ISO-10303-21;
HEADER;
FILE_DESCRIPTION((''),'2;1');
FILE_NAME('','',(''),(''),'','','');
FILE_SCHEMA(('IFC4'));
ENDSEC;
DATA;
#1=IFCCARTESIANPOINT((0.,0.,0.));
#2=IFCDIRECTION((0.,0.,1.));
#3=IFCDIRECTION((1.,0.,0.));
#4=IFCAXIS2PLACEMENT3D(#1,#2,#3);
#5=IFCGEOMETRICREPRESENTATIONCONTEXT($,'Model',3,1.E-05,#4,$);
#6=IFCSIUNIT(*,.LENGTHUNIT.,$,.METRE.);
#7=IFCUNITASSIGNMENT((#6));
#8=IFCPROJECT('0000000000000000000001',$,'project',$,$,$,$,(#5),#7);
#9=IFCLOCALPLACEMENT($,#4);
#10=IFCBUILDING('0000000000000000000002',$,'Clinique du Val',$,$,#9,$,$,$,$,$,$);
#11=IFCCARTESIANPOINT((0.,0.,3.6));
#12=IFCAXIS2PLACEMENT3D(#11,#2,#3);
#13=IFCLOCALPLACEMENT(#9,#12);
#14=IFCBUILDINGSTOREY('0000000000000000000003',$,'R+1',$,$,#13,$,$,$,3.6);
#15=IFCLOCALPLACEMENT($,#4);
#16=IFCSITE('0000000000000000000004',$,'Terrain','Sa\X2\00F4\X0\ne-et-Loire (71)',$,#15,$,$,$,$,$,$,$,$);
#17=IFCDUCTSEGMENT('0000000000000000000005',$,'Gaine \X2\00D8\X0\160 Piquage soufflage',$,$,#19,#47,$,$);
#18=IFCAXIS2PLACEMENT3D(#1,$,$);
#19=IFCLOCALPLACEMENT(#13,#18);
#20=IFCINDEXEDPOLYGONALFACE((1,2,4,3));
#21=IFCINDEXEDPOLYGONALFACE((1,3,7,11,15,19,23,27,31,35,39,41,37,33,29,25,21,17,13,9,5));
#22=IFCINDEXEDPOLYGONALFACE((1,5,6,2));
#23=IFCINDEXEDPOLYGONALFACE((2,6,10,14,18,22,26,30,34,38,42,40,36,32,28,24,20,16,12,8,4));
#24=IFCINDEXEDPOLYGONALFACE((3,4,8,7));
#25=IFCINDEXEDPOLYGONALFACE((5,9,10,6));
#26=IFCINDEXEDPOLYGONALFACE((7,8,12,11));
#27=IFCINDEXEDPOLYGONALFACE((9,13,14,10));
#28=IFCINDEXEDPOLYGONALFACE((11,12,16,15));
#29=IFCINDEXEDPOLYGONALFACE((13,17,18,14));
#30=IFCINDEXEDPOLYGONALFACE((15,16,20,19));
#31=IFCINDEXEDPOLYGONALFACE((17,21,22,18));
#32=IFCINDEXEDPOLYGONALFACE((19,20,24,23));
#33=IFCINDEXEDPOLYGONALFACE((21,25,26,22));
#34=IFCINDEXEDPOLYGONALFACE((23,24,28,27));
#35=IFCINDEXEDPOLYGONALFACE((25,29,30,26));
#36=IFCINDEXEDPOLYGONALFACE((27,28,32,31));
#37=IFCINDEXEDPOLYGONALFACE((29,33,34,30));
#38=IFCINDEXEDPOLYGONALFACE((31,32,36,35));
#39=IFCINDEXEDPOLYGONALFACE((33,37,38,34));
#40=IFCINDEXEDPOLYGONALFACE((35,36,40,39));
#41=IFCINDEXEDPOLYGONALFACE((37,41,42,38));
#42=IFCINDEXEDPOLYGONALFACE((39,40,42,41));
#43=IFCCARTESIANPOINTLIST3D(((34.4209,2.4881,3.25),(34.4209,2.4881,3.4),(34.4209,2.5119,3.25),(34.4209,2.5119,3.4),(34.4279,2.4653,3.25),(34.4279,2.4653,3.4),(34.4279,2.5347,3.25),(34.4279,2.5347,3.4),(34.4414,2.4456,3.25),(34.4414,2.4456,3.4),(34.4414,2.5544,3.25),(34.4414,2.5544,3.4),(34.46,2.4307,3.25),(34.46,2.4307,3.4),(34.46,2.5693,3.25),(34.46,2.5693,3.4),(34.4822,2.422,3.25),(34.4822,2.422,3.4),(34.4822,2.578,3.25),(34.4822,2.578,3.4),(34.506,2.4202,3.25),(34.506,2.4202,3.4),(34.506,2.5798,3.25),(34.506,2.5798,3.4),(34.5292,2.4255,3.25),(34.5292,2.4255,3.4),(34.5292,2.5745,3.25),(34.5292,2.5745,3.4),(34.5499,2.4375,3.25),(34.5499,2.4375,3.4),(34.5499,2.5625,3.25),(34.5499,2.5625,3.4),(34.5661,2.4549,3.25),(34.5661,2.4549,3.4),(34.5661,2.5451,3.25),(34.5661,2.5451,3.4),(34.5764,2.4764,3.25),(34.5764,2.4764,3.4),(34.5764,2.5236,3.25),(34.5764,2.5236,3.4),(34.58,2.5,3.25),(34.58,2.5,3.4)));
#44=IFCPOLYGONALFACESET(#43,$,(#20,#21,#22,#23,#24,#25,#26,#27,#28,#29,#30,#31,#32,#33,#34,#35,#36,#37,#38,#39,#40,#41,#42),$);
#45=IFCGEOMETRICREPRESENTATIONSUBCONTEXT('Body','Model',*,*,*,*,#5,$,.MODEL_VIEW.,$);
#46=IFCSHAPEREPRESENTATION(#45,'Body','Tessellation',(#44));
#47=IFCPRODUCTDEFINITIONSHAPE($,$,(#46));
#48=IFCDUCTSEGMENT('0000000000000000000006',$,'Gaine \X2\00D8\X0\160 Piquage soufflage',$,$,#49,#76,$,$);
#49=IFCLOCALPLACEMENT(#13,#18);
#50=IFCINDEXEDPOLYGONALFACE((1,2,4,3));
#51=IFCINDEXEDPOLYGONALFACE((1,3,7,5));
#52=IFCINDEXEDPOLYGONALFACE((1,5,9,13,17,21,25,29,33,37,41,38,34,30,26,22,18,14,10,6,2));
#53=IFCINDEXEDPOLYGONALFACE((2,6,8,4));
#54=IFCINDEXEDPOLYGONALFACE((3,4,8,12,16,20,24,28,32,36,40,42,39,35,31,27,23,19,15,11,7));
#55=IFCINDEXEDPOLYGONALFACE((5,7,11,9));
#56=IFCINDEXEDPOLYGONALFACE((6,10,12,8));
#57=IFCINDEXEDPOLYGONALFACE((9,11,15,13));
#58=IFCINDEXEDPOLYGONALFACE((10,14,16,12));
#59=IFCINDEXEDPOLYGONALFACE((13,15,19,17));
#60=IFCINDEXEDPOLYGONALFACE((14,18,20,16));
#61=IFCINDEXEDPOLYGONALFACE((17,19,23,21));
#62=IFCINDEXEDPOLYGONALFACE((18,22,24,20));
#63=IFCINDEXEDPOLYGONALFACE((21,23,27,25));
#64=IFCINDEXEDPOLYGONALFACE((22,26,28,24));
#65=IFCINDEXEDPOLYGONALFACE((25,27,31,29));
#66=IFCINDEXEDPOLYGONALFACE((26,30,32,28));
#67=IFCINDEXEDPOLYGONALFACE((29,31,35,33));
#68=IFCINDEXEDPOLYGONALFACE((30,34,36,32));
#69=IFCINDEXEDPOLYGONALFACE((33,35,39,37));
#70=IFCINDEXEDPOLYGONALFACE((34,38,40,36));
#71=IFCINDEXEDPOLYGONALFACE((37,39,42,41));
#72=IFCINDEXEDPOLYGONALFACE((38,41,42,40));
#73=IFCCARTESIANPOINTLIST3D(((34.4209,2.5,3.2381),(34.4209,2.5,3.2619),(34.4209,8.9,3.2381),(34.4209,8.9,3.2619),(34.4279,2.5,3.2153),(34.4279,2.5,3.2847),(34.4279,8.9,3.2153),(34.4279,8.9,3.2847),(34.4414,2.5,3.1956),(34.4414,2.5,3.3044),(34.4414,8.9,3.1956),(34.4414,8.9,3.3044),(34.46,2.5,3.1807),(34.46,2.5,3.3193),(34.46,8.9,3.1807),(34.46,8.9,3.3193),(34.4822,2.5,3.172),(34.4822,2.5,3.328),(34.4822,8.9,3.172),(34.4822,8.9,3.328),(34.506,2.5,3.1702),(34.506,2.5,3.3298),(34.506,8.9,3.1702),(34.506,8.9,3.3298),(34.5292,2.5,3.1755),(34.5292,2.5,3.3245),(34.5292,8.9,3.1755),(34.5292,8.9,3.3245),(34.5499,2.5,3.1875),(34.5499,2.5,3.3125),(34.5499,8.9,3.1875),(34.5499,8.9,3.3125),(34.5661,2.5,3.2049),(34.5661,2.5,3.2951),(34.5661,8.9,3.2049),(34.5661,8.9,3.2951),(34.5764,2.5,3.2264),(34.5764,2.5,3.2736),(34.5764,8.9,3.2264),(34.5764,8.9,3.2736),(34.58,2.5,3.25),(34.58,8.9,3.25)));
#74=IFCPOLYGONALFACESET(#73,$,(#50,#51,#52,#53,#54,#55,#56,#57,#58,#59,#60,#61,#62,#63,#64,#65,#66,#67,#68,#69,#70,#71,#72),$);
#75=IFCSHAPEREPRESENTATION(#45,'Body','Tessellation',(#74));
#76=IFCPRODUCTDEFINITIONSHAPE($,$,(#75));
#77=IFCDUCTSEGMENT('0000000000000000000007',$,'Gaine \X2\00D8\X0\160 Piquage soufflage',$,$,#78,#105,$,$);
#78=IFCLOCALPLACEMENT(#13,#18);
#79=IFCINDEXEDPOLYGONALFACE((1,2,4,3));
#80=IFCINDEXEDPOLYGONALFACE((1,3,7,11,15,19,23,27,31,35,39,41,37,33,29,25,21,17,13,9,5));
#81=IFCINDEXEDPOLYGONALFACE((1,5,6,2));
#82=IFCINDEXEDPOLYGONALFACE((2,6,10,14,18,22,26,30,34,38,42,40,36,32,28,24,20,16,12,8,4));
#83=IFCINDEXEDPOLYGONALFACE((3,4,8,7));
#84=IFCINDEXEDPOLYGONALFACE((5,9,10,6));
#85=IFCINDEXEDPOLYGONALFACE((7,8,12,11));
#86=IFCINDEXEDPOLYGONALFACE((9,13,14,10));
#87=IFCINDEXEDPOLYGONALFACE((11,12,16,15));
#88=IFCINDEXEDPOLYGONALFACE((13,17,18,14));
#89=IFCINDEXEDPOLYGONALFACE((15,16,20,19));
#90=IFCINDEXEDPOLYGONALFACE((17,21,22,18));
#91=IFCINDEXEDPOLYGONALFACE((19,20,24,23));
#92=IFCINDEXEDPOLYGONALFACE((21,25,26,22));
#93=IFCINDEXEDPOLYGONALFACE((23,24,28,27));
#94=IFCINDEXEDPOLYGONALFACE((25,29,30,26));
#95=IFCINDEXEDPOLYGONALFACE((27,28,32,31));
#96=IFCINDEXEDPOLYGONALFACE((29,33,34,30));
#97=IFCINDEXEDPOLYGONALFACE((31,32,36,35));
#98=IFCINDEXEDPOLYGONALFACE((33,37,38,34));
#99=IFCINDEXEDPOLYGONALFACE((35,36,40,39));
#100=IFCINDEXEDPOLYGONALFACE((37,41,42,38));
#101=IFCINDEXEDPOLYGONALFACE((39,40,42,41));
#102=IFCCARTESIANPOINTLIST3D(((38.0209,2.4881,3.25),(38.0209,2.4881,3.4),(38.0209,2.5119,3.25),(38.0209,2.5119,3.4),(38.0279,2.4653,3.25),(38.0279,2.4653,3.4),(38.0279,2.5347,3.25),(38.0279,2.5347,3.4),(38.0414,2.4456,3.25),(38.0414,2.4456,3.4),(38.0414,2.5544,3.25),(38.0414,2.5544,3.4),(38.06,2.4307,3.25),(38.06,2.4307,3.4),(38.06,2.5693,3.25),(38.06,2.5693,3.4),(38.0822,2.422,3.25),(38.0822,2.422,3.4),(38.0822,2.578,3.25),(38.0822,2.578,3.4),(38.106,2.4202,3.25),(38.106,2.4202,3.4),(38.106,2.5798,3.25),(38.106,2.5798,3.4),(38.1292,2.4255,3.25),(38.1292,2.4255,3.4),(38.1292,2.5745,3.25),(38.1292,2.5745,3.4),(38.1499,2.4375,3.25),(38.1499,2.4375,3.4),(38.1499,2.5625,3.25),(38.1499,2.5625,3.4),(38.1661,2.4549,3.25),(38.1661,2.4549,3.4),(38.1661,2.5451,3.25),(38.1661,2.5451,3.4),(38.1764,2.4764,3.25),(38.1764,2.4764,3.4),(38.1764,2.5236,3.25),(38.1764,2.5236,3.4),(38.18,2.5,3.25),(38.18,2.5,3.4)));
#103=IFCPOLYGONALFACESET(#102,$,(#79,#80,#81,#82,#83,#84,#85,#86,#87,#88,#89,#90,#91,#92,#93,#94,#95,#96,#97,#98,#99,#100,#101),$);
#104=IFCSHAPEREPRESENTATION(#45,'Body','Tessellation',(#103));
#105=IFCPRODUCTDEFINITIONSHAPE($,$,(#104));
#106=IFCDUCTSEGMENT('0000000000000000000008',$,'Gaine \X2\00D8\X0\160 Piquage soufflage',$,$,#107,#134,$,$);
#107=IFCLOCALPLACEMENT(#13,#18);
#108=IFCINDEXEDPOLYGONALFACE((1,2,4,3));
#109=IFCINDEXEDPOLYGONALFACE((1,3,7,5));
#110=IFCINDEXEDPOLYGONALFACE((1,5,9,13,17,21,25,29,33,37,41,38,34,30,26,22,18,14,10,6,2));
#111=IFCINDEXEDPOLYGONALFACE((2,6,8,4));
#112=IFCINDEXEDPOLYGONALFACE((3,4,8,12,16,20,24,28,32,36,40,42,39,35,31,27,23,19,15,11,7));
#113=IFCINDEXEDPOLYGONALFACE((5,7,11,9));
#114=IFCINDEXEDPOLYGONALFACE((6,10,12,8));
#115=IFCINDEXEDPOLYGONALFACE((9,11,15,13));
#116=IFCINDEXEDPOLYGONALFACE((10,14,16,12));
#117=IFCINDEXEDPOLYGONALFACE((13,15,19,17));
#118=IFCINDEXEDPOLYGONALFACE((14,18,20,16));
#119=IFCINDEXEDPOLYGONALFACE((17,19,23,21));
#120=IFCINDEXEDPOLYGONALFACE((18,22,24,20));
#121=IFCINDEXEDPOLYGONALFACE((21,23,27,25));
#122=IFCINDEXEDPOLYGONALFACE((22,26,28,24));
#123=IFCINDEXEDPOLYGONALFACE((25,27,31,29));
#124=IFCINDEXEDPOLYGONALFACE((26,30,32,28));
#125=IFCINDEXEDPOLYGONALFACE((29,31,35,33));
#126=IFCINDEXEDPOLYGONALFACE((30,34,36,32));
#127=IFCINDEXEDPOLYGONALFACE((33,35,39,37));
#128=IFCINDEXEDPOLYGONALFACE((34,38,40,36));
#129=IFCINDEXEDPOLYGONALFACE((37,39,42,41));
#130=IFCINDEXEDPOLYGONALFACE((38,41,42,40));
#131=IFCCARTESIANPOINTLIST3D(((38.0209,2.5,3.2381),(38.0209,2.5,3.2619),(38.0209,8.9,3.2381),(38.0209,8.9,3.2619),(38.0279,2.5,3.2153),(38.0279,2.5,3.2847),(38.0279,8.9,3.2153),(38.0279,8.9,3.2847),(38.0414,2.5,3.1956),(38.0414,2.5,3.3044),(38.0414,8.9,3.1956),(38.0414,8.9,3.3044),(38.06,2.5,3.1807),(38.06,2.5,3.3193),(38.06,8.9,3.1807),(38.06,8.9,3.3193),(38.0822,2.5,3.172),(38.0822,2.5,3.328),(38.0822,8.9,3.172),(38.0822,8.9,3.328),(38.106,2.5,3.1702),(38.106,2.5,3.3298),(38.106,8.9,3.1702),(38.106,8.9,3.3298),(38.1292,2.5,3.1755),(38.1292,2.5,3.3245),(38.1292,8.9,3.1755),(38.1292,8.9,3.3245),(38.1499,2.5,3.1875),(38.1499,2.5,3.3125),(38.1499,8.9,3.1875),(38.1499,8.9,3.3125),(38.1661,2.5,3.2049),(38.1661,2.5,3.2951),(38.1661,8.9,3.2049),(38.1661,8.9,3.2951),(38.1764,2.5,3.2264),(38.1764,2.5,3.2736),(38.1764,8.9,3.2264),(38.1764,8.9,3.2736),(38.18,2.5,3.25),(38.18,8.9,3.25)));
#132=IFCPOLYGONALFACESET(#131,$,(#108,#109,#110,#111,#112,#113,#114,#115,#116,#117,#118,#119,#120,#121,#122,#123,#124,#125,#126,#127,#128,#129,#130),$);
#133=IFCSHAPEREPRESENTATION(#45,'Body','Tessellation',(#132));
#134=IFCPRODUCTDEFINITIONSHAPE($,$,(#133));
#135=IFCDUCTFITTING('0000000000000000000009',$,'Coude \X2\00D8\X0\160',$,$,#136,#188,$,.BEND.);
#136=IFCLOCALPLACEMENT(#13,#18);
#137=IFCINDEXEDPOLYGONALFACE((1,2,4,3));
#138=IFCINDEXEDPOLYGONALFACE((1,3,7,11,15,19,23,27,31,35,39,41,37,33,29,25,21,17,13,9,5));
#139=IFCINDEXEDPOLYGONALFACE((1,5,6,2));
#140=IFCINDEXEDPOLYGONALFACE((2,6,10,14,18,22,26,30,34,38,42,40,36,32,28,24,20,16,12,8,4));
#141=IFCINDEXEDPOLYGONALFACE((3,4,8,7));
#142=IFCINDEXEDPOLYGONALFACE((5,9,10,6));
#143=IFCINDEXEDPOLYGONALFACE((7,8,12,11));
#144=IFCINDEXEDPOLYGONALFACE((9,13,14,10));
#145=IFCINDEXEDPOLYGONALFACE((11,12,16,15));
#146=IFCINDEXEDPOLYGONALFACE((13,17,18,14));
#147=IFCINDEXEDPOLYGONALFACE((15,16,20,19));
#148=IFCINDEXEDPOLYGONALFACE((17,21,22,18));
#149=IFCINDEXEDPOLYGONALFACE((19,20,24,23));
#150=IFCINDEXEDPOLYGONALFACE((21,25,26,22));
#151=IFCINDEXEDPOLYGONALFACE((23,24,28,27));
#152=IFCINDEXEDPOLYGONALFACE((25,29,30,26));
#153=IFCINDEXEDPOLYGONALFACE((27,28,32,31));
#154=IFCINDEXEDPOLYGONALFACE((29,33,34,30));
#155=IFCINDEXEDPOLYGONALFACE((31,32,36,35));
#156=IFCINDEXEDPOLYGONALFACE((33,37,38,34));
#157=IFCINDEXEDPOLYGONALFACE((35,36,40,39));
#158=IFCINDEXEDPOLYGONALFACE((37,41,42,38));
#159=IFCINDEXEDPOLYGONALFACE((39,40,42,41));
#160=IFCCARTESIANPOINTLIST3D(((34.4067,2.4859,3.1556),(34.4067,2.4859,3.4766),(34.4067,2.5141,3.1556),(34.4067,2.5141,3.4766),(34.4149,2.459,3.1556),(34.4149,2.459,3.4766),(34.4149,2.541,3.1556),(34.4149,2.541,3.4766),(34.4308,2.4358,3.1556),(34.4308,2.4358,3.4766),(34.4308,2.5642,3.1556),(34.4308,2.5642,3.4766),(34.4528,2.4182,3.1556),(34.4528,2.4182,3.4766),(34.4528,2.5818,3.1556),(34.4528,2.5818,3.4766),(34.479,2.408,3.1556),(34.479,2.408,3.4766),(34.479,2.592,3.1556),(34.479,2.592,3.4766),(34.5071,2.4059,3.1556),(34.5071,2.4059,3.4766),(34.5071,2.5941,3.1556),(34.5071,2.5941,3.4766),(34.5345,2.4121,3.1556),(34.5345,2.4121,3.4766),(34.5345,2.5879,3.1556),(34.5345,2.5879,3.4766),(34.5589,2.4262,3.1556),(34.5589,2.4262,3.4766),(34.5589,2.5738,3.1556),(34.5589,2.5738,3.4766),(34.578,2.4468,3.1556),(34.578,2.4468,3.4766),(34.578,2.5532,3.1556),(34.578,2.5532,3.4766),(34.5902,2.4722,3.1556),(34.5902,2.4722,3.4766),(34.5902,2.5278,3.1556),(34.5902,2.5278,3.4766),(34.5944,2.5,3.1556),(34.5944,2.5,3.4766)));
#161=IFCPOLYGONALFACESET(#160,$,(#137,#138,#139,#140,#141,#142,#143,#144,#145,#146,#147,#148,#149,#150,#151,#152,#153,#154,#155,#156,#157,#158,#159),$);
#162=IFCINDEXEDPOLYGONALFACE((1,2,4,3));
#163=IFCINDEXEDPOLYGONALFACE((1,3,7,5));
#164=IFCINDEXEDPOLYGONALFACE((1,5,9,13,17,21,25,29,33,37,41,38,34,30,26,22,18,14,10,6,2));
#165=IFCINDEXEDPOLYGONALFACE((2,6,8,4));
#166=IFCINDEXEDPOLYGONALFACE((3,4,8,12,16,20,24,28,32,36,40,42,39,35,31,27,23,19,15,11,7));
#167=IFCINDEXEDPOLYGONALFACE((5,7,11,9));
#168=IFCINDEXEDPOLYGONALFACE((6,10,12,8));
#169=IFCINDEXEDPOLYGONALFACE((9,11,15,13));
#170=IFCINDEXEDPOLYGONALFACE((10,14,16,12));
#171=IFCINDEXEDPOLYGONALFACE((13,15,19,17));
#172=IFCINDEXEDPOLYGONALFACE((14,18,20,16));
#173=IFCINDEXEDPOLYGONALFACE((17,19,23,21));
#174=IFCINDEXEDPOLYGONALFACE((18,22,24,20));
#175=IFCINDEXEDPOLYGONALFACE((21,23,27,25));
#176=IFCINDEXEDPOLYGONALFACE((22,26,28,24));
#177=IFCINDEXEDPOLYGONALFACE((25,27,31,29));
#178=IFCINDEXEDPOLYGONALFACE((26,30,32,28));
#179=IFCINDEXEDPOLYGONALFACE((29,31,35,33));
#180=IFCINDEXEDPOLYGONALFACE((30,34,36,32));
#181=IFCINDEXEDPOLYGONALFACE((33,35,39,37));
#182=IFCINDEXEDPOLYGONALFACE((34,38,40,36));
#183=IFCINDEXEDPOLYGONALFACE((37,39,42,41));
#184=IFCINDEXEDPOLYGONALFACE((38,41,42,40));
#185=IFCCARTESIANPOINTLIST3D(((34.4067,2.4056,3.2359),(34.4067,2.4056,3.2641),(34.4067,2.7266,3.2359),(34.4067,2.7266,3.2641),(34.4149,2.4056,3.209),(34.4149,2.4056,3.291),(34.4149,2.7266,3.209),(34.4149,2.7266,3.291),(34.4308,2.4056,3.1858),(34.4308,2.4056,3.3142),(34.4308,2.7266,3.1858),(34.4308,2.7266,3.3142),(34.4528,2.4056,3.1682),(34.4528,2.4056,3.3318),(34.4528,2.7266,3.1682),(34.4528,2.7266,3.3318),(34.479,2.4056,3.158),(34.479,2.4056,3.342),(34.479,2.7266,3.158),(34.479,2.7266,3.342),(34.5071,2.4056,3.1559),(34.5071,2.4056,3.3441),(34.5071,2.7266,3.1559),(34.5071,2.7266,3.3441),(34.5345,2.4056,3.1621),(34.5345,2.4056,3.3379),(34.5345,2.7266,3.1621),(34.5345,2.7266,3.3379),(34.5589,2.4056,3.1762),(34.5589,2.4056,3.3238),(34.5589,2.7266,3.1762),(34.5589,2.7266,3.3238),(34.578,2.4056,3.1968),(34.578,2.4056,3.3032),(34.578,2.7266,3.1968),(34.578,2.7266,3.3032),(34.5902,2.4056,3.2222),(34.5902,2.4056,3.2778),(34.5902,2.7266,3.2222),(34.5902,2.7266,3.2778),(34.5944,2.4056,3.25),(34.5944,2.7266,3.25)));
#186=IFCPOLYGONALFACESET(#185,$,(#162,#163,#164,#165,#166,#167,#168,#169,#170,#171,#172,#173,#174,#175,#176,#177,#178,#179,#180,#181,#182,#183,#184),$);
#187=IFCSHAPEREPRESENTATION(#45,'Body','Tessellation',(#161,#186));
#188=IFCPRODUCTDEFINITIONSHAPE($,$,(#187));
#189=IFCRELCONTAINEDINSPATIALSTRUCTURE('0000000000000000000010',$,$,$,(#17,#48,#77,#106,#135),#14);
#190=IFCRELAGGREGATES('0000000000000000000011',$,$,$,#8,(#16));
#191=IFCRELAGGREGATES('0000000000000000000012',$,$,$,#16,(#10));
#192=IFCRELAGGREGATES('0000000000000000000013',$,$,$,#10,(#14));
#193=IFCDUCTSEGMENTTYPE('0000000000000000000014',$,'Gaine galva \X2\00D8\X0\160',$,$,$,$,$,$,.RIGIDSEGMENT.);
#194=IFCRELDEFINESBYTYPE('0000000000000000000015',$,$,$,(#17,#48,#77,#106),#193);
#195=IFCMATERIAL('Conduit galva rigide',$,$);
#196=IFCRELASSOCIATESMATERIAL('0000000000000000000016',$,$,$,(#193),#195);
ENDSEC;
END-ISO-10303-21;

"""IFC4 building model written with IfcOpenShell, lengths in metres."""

from ifc_helpers import new_model, si_unit, frame, origin_with_axes, place, context, subcontext, project, spatial, circle, extrude, material, type_object, element, save


model = new_model("IFC4")

# Units and contexts
model_context = context("Model", 3, precision=1e-05, world=origin_with_axes())
body_context = subcontext(model_context, "Body", "Model", "MODEL_VIEW")
ifc_project = project(units=[si_unit("LENGTHUNIT", "METRE")], contexts=[model_context])

# Site, building, storey
site_placement = place(None, origin_with_axes())
site = spatial("IfcSite", under=ifc_project, at=site_placement, Name="Terrain", Description="Saône-et-Loire (71)")
building_placement = place(None, origin_with_axes())
building = spatial("IfcBuilding", under=site, at=building_placement, Name="Clinique du Val")
storey_placement = place(building_placement, frame((0.0, 0.0, 3.6), z_axis=(0.0, 0.0, 1.0), x_axis=(1.0, 0.0, 0.0)))
storey = spatial("IfcBuildingStorey", under=building, at=storey_placement, Name="R+1", Elevation=3.6)

# Duct segments
ifc_material_1 = material(Name="Conduit galva rigide")
duct_segment_type = type_object("IfcDuctSegmentType", Name="Gaine galva Ø160", PredefinedType="RIGIDSEGMENT", material=ifc_material_1)
duct_segment_1_placement = place(storey_placement, frame((34.5, 2.5, 3.4), z_axis=(0.0, 0.0, -1.0), x_axis=(1.0, 0.0, 0.0)))
element("IfcDuctSegment", 1, at=duct_segment_1_placement, inside=storey, type_object=duct_segment_type, Name="Gaine Ø160 Piquage soufflage", context=body_context, shape_type="SweptSolid", body=[
    extrude(circle(Radius=0.08), origin_with_axes(), (0.0, 0.0, 1.0), 0.15),
])
duct_segment_2_placement = place(storey_placement, frame((34.5, 2.5, 3.25), z_axis=(0.0, 1.0, 0.0), x_axis=(1.0, 0.0, 0.0)))
element("IfcDuctSegment", 2, at=duct_segment_2_placement, inside=storey, type_object=duct_segment_type, Name="Gaine Ø160 Piquage soufflage", context=body_context, shape_type="SweptSolid", body=[
    extrude(circle(Radius=0.08), origin_with_axes(), (0.0, 0.0, 1.0), 6.4),
])
duct_segment_3_placement = place(storey_placement, frame((38.1, 2.5, 3.4), z_axis=(0.0, 0.0, -1.0), x_axis=(1.0, 0.0, 0.0)))
element("IfcDuctSegment", 3, at=duct_segment_3_placement, inside=storey, type_object=duct_segment_type, Name="Gaine Ø160 Piquage soufflage", context=body_context, shape_type="SweptSolid", body=[
    extrude(circle(Radius=0.08), origin_with_axes(), (0.0, 0.0, 1.0), 0.15),
])
duct_segment_4_placement = place(storey_placement, frame((38.1, 2.5, 3.25), z_axis=(0.0, 1.0, 0.0), x_axis=(1.0, 0.0, 0.0)))
element("IfcDuctSegment", 4, at=duct_segment_4_placement, inside=storey, type_object=duct_segment_type, Name="Gaine Ø160 Piquage soufflage", context=body_context, shape_type="SweptSolid", body=[
    extrude(circle(Radius=0.08), origin_with_axes(), (0.0, 0.0, 1.0), 6.4),
])

# Duct fitting
duct_fitting_1_placement = place(storey_placement, frame((34.5, 2.5, 3.25), z_axis=(0.0, 0.0, 1.0), x_axis=(1.0, 0.0, 0.0)))
element("IfcDuctFitting", 5, at=duct_fitting_1_placement, inside=storey, Name="Coude Ø160", PredefinedType="BEND", context=body_context, shape_type="SweptSolid", body=[
    extrude(circle(Radius=0.0944), frame((0.0, 0.0, -0.0944), z_axis=(0.0, 0.0, 1.0), x_axis=(1.0, 0.0, 0.0)), (0.0, 0.0, 1.0), 0.321),
    extrude(circle(Radius=0.0944), frame((0.0, -0.0944, 0.0), z_axis=(0.0, 1.0, 0.0), x_axis=(1.0, 0.0, 0.0)), (0.0, 0.0, 1.0), 0.321),
])

save(model, "model.ifc")
